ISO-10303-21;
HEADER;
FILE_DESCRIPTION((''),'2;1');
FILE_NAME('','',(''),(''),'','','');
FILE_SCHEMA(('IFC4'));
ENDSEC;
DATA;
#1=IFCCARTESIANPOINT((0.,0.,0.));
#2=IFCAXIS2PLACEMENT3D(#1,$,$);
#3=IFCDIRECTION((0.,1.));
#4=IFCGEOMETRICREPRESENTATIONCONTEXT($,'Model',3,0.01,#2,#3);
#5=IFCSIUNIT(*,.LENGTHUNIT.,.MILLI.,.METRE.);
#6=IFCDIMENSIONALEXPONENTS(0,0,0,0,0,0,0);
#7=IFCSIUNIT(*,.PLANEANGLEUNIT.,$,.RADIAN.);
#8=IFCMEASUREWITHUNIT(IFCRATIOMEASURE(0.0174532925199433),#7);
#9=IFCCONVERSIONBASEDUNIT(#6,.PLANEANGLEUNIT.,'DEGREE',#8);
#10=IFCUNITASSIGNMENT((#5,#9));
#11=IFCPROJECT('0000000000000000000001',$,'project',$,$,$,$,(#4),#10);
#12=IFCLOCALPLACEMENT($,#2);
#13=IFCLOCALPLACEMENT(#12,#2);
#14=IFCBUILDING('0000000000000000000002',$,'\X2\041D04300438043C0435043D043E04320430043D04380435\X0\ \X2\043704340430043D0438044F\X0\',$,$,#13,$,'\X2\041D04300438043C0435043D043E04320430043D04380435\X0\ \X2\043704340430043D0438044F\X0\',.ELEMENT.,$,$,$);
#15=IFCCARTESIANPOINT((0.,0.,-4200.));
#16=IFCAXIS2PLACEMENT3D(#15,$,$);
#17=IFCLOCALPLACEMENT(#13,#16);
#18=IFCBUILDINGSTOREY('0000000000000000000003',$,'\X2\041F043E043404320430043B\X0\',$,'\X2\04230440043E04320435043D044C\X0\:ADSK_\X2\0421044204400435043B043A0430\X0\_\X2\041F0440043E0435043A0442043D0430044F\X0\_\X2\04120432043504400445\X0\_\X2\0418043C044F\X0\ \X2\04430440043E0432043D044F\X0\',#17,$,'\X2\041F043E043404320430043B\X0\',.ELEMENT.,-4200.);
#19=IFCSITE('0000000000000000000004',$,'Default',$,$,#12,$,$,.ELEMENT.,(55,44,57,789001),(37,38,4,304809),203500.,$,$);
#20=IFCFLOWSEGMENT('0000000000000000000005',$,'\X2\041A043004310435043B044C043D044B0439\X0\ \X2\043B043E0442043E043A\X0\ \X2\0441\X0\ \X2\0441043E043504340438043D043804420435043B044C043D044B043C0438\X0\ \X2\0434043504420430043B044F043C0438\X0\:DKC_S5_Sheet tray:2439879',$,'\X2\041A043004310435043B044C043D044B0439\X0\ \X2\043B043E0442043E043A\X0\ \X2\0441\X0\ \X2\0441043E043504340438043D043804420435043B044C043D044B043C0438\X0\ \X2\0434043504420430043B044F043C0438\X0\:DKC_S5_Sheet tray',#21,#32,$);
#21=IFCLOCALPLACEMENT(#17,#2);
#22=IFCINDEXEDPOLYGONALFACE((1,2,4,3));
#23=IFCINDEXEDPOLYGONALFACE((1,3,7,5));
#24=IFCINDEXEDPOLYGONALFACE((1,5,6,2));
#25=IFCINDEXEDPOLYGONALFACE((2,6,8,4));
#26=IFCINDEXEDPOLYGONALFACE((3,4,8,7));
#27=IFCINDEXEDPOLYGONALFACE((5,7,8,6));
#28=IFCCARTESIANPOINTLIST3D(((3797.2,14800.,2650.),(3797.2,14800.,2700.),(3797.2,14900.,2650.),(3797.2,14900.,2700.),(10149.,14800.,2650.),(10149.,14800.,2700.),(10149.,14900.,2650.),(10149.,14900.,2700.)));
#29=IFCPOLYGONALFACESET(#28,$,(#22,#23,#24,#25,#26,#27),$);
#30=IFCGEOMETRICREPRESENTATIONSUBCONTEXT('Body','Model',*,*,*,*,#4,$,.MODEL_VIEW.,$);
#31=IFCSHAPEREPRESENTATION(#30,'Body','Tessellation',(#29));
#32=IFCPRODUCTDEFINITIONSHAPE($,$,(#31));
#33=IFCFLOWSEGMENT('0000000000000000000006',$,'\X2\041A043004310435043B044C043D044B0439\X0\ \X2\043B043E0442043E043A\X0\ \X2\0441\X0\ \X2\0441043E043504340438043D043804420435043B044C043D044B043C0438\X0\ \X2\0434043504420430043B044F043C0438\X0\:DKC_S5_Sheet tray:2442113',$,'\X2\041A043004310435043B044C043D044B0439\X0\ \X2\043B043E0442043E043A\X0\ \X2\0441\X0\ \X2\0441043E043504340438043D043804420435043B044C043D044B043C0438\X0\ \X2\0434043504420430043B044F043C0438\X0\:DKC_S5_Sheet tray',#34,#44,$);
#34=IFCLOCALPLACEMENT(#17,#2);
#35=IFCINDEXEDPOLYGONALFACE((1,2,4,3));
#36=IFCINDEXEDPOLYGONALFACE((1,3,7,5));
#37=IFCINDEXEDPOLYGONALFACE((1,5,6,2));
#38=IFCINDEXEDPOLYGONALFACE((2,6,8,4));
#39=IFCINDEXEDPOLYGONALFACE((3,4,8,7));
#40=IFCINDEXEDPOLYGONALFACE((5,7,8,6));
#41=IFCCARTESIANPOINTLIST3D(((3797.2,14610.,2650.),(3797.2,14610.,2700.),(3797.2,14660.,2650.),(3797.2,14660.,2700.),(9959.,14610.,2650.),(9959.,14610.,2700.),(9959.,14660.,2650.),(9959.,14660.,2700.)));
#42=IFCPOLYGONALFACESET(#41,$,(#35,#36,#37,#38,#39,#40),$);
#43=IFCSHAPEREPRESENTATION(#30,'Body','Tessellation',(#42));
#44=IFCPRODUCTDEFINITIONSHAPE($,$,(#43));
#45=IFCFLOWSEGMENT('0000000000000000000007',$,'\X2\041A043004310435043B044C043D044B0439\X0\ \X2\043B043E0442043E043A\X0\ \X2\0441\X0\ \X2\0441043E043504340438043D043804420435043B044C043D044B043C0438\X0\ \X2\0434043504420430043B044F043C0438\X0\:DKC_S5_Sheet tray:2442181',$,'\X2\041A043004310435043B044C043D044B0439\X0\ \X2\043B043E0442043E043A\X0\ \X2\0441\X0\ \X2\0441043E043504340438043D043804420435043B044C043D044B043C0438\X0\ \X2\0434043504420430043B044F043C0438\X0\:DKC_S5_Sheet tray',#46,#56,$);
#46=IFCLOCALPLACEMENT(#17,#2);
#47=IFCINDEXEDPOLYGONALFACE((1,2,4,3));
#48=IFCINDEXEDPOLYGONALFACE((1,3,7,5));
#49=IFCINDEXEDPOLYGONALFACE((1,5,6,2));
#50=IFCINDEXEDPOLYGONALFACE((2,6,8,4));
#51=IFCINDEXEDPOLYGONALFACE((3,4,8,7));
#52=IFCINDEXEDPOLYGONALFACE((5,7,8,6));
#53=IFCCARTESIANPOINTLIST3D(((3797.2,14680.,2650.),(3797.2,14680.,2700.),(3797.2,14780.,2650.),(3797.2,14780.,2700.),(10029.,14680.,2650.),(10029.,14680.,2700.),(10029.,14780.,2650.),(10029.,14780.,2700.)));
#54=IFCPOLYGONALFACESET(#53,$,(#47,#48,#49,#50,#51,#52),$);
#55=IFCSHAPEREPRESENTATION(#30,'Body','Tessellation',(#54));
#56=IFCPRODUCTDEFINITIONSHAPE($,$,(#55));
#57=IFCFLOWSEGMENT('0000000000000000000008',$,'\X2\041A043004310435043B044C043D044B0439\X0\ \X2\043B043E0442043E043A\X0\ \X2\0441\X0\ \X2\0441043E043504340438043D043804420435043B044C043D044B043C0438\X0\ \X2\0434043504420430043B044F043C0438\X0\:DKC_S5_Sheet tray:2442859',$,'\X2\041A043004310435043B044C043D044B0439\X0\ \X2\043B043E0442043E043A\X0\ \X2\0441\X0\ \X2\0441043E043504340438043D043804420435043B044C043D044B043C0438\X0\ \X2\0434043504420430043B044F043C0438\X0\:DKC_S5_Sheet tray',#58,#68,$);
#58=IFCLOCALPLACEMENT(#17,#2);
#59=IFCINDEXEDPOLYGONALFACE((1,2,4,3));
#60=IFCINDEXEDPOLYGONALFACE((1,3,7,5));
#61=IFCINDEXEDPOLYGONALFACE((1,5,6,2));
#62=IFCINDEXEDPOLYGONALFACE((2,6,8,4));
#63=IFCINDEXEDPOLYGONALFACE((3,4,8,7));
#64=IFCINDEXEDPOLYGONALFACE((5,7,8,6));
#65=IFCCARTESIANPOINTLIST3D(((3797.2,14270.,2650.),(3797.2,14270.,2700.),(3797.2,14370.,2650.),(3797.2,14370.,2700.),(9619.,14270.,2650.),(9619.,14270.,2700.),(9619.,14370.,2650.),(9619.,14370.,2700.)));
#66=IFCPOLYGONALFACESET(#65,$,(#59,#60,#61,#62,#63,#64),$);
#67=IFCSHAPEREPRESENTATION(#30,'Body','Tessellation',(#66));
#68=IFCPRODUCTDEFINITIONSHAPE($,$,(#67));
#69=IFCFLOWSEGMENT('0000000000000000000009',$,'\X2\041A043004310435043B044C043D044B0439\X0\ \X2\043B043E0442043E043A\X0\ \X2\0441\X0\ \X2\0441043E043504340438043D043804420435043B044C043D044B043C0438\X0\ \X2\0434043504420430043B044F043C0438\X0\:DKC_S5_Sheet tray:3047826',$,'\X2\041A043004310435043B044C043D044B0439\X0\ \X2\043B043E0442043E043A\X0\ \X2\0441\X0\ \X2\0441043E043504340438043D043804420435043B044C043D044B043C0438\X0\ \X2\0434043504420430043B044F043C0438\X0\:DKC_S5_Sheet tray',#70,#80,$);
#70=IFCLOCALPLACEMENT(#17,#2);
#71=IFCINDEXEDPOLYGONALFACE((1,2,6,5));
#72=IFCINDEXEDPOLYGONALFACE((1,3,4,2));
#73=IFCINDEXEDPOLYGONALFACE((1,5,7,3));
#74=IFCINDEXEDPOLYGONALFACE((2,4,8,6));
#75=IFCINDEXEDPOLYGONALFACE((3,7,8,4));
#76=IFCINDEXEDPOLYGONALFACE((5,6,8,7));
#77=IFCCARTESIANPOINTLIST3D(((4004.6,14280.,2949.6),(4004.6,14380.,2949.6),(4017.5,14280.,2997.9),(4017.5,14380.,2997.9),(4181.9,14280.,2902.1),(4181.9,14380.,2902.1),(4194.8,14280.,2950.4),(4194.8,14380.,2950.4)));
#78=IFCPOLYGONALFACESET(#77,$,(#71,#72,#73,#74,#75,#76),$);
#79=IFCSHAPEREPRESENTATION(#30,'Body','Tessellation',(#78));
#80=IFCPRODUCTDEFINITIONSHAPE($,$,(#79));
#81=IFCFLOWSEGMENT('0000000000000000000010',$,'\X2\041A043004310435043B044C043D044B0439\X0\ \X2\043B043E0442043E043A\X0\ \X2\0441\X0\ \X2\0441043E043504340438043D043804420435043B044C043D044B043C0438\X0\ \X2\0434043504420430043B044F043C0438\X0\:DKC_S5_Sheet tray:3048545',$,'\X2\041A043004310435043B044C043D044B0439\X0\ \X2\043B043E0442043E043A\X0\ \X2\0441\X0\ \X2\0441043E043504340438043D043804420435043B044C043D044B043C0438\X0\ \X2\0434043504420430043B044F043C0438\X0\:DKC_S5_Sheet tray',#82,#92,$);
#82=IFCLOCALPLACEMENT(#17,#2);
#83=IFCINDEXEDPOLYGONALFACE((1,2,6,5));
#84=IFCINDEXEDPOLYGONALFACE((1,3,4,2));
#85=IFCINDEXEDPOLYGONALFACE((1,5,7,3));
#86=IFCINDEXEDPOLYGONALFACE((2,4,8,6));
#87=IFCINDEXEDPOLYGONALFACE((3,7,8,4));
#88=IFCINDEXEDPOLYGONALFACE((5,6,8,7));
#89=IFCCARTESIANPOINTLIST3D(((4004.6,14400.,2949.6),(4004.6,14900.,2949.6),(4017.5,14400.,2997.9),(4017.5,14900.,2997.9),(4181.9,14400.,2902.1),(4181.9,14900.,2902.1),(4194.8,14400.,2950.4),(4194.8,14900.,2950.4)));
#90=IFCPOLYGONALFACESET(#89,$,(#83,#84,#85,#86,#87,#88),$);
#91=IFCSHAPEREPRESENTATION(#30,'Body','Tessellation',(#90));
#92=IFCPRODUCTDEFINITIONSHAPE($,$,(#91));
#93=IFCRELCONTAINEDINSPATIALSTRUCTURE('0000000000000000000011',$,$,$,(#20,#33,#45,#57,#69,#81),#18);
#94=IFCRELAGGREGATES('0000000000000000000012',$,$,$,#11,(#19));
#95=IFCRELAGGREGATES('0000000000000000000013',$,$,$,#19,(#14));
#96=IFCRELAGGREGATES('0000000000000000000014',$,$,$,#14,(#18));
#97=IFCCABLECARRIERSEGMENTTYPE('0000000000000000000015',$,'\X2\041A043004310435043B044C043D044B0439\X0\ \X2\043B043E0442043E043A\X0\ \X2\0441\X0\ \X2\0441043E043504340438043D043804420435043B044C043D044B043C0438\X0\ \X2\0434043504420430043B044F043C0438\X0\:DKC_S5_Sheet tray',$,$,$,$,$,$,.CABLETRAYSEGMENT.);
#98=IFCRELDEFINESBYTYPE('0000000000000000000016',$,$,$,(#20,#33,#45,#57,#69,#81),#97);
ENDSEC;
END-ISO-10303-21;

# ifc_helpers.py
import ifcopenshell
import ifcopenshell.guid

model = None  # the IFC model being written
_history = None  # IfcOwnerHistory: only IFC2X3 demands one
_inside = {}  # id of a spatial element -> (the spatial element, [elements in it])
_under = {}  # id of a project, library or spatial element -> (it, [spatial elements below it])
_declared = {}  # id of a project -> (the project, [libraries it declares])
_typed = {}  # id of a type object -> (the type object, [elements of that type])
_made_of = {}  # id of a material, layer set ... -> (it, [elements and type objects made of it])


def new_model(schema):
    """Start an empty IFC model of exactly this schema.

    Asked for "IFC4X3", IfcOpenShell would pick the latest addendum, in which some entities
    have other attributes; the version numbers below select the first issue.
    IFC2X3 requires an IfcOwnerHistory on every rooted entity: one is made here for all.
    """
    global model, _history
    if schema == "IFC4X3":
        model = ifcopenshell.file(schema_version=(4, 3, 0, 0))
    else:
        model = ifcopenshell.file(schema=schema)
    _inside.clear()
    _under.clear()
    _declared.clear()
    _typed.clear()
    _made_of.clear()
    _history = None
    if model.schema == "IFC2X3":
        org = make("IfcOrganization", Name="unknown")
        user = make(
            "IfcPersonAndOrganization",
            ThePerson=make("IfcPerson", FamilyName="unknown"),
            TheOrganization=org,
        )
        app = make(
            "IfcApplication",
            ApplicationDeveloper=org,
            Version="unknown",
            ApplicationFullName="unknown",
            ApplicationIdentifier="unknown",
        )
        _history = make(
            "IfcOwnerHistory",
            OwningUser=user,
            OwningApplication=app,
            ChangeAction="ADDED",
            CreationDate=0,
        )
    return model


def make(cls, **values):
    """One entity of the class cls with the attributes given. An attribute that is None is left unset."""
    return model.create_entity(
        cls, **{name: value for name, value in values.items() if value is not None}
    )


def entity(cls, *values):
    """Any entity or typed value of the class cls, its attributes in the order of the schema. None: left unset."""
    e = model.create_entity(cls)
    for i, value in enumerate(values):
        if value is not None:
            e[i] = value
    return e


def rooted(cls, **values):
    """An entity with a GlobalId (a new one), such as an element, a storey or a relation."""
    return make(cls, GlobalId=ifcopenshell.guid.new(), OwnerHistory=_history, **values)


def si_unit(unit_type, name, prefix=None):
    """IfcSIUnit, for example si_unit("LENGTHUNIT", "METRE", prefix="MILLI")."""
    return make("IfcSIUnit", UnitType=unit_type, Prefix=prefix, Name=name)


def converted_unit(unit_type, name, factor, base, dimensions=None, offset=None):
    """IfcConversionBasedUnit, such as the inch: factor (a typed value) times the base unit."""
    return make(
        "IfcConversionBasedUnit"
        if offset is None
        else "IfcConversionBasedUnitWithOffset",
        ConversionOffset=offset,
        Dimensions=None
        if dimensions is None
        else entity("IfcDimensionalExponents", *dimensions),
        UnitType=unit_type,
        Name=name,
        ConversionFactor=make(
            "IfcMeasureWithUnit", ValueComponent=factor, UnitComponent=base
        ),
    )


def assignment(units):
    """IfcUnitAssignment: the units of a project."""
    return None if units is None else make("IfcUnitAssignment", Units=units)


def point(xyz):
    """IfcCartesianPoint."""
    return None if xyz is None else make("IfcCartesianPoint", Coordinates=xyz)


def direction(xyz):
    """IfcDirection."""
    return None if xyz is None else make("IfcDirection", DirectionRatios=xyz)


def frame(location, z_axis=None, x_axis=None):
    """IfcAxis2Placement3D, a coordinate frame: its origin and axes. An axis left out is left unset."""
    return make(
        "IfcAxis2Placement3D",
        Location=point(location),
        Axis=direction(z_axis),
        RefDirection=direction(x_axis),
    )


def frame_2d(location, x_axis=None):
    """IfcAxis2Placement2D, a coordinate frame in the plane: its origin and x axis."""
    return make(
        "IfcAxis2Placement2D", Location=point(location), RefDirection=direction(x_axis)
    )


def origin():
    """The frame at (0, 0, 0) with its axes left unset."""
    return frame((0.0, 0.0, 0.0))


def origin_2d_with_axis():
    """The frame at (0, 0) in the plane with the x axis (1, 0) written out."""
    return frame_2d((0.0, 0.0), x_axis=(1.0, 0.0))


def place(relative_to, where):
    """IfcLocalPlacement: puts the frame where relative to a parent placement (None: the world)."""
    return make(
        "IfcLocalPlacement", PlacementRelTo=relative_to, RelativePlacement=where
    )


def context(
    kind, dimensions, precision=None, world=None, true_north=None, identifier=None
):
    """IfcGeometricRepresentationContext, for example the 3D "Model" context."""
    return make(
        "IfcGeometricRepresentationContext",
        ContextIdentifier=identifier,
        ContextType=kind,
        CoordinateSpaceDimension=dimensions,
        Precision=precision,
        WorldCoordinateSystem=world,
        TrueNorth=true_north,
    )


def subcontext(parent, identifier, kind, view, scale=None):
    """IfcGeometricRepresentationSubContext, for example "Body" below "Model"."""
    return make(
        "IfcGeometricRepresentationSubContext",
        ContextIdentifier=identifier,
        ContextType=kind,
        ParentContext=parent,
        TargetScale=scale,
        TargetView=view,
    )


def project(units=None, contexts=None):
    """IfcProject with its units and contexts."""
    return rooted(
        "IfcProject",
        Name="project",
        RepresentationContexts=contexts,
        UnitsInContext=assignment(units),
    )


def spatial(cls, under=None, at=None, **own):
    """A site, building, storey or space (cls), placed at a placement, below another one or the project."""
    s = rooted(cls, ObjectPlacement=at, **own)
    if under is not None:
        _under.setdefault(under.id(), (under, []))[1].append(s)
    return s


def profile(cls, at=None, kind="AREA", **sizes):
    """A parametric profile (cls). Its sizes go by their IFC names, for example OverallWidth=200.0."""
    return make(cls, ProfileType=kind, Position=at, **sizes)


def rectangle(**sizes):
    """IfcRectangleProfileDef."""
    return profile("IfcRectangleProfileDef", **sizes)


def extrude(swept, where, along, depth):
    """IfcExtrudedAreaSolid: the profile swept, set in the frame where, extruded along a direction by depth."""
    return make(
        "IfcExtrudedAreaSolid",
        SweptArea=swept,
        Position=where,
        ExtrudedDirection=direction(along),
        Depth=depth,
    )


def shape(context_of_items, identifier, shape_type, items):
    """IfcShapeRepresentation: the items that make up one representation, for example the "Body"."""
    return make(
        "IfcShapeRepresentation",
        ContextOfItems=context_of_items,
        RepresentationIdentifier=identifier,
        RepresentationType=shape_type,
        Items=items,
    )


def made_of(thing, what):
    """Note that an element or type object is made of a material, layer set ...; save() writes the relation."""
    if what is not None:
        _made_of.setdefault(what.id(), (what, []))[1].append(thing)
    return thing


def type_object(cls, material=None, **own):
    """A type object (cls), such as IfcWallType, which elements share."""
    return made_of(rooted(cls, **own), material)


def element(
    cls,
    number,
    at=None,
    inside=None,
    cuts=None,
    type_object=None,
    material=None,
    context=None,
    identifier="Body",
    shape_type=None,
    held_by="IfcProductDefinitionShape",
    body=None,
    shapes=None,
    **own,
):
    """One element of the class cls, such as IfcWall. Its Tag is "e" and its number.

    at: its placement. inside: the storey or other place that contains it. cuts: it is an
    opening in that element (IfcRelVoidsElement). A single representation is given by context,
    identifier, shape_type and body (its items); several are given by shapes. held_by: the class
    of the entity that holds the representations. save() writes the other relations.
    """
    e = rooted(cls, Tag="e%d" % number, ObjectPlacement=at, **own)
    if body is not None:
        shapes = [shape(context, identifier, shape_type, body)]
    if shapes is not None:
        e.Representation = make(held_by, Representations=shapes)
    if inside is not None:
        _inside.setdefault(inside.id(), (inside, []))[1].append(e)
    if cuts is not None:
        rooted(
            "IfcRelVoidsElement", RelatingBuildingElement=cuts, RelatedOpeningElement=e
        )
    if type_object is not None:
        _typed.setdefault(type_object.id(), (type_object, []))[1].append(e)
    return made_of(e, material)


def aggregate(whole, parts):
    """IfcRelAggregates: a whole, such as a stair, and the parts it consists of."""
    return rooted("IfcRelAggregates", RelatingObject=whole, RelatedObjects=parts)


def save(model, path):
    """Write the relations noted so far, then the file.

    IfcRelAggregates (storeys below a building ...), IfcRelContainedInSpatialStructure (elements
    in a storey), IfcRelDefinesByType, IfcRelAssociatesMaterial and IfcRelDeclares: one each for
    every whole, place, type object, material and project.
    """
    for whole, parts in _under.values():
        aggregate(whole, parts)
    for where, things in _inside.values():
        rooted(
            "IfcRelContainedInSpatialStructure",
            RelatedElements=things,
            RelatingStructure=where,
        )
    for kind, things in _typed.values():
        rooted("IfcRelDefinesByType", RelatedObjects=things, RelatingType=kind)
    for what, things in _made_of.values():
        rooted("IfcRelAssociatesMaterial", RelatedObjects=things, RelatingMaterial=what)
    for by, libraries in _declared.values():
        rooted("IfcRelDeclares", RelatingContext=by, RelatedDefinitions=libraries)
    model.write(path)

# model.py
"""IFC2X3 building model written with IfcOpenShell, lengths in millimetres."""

from ifc_helpers import new_model, entity, si_unit, converted_unit, direction, frame, frame_2d, origin, origin_2d_with_axis, place, context, subcontext, project, spatial, rectangle, extrude, type_object, element, save


model = new_model("IFC2X3")

# Units and contexts
model_context = context("Model", 3, precision=0.01, world=origin(), true_north=direction((0.0, 1.0)))
body_context = subcontext(model_context, "Body", "Model", "MODEL_VIEW")
ifc_project = project(units=[si_unit("LENGTHUNIT", "METRE", prefix="MILLI"), converted_unit("PLANEANGLEUNIT", "DEGREE", entity("IfcRatioMeasure", 0.0174532925199433), si_unit("PLANEANGLEUNIT", "RADIAN"), dimensions=[0, 0, 0, 0, 0, 0, 0])], contexts=[model_context])

# Site, building, storey
site_placement = place(None, frame((0.0, 0.0, 0.0)))
site = spatial("IfcSite", under=ifc_project, at=site_placement, Name="Default", CompositionType="ELEMENT", RefLatitude=(55, 44, 57, 789001), RefLongitude=(37, 38, 4, 304809), RefElevation=203500.0)
building_placement = place(site_placement, origin())
building = spatial("IfcBuilding", under=site, at=building_placement, Name="Наименование здания", LongName="Наименование здания", CompositionType="ELEMENT")
storey_placement = place(building_placement, frame((0.0, 0.0, -4200.0)))
storey = spatial("IfcBuildingStorey", under=building, at=storey_placement, Name="Подвал", ObjectType="Уровень:ADSK_Стрелка_Проектная_Вверх_Имя уровня", LongName="Подвал", CompositionType="ELEMENT", Elevation=-4200.0)

# Flow segments
cable_carrier_segment_type = type_object("IfcCableCarrierSegmentType", Name="Кабельный лоток с соединительными деталями:DKC_S5_Sheet tray", PredefinedType="CABLETRAYSEGMENT")
flow_segment_1_placement = place(storey_placement, frame((3797.2, 14800.0, 2650.0)))
element("IfcFlowSegment", 1, at=flow_segment_1_placement, inside=storey, type_object=cable_carrier_segment_type, Name="Кабельный лоток с соединительными деталями:DKC_S5_Sheet tray:2439879", ObjectType="Кабельный лоток с соединительными деталями:DKC_S5_Sheet tray", context=body_context, shape_type="SweptSolid", body=[
    extrude(rectangle(XDim=6351.8, YDim=100.0, at=origin_2d_with_axis()), frame((3175.9, 50.0, 0.0), z_axis=(0.0, 0.0, 1.0), x_axis=(-1.0, 0.0, 0.0)), (0.0, 0.0, 1.0), 50.0),
])
flow_segment_2_placement = place(storey_placement, frame((3797.2, 14610.0, 2650.0)))
element("IfcFlowSegment", 2, at=flow_segment_2_placement, inside=storey, type_object=cable_carrier_segment_type, Name="Кабельный лоток с соединительными деталями:DKC_S5_Sheet tray:2442113", ObjectType="Кабельный лоток с соединительными деталями:DKC_S5_Sheet tray", context=body_context, shape_type="SweptSolid", body=[
    extrude(rectangle(XDim=6161.8, YDim=50.0, at=origin_2d_with_axis()), frame((3080.9, 25.0, 0.0), z_axis=(0.0, 0.0, 1.0), x_axis=(-1.0, 0.0, 0.0)), (0.0, 0.0, 1.0), 50.0),
])
flow_segment_3_placement = place(storey_placement, frame((3797.2, 14680.0, 2650.0)))
element("IfcFlowSegment", 3, at=flow_segment_3_placement, inside=storey, type_object=cable_carrier_segment_type, Name="Кабельный лоток с соединительными деталями:DKC_S5_Sheet tray:2442181", ObjectType="Кабельный лоток с соединительными деталями:DKC_S5_Sheet tray", context=body_context, shape_type="SweptSolid", body=[
    extrude(rectangle(XDim=6231.8, YDim=100.0, at=origin_2d_with_axis()), frame((3115.9, 50.0, 0.0), z_axis=(0.0, 0.0, 1.0), x_axis=(-1.0, 0.0, 0.0)), (0.0, 0.0, 1.0), 50.0),
])
flow_segment_4_placement = place(storey_placement, frame((3797.2, 14270.0, 2650.0)))
element("IfcFlowSegment", 4, at=flow_segment_4_placement, inside=storey, type_object=cable_carrier_segment_type, Name="Кабельный лоток с соединительными деталями:DKC_S5_Sheet tray:2442859", ObjectType="Кабельный лоток с соединительными деталями:DKC_S5_Sheet tray", context=body_context, shape_type="SweptSolid", body=[
    extrude(rectangle(XDim=5821.8, YDim=100.0, at=frame_2d((0.0, 0.0), x_axis=(1.0, 0.0))), frame((2910.9, 50.0, 0.0), z_axis=(0.0, 0.0, 1.0), x_axis=(-1.0, 0.0, 0.0)), (0.0, 0.0, 1.0), 50.0),
])
flow_segment_5_placement = place(storey_placement, frame((4004.6, 14280.0, 2902.1)))
element("IfcFlowSegment", 5, at=flow_segment_5_placement, inside=storey, type_object=cable_carrier_segment_type, Name="Кабельный лоток с соединительными деталями:DKC_S5_Sheet tray:3047826", ObjectType="Кабельный лоток с соединительными деталями:DKC_S5_Sheet tray", context=body_context, shape_type="SweptSolid", body=[
    extrude(rectangle(XDim=50.0, YDim=100.0, at=origin_2d_with_axis()), frame((6.5, 50.0, 71.7), z_axis=(0.965926, 0.0, -0.258819), x_axis=(0.258819, 0.0, 0.965926)), (0.0, 0.0, 1.0), 183.5),
])
flow_segment_6_placement = place(storey_placement, frame((4004.6, 14400.0, 2902.1)))
element("IfcFlowSegment", 6, at=flow_segment_6_placement, inside=storey, type_object=cable_carrier_segment_type, Name="Кабельный лоток с соединительными деталями:DKC_S5_Sheet tray:3048545", ObjectType="Кабельный лоток с соединительными деталями:DKC_S5_Sheet tray", context=body_context, shape_type="SweptSolid", body=[
    extrude(rectangle(XDim=50.0, YDim=183.5, at=frame_2d((0.0, 0.0), x_axis=(0.0, 1.0))), frame((95.1, 0.0, 47.9), z_axis=(0.0, 1.0, 0.0), x_axis=(-0.965926, 0.0, 0.258819)), (0.0, 0.0, 1.0), 500.0),
])

save(model, "model.ifc")
